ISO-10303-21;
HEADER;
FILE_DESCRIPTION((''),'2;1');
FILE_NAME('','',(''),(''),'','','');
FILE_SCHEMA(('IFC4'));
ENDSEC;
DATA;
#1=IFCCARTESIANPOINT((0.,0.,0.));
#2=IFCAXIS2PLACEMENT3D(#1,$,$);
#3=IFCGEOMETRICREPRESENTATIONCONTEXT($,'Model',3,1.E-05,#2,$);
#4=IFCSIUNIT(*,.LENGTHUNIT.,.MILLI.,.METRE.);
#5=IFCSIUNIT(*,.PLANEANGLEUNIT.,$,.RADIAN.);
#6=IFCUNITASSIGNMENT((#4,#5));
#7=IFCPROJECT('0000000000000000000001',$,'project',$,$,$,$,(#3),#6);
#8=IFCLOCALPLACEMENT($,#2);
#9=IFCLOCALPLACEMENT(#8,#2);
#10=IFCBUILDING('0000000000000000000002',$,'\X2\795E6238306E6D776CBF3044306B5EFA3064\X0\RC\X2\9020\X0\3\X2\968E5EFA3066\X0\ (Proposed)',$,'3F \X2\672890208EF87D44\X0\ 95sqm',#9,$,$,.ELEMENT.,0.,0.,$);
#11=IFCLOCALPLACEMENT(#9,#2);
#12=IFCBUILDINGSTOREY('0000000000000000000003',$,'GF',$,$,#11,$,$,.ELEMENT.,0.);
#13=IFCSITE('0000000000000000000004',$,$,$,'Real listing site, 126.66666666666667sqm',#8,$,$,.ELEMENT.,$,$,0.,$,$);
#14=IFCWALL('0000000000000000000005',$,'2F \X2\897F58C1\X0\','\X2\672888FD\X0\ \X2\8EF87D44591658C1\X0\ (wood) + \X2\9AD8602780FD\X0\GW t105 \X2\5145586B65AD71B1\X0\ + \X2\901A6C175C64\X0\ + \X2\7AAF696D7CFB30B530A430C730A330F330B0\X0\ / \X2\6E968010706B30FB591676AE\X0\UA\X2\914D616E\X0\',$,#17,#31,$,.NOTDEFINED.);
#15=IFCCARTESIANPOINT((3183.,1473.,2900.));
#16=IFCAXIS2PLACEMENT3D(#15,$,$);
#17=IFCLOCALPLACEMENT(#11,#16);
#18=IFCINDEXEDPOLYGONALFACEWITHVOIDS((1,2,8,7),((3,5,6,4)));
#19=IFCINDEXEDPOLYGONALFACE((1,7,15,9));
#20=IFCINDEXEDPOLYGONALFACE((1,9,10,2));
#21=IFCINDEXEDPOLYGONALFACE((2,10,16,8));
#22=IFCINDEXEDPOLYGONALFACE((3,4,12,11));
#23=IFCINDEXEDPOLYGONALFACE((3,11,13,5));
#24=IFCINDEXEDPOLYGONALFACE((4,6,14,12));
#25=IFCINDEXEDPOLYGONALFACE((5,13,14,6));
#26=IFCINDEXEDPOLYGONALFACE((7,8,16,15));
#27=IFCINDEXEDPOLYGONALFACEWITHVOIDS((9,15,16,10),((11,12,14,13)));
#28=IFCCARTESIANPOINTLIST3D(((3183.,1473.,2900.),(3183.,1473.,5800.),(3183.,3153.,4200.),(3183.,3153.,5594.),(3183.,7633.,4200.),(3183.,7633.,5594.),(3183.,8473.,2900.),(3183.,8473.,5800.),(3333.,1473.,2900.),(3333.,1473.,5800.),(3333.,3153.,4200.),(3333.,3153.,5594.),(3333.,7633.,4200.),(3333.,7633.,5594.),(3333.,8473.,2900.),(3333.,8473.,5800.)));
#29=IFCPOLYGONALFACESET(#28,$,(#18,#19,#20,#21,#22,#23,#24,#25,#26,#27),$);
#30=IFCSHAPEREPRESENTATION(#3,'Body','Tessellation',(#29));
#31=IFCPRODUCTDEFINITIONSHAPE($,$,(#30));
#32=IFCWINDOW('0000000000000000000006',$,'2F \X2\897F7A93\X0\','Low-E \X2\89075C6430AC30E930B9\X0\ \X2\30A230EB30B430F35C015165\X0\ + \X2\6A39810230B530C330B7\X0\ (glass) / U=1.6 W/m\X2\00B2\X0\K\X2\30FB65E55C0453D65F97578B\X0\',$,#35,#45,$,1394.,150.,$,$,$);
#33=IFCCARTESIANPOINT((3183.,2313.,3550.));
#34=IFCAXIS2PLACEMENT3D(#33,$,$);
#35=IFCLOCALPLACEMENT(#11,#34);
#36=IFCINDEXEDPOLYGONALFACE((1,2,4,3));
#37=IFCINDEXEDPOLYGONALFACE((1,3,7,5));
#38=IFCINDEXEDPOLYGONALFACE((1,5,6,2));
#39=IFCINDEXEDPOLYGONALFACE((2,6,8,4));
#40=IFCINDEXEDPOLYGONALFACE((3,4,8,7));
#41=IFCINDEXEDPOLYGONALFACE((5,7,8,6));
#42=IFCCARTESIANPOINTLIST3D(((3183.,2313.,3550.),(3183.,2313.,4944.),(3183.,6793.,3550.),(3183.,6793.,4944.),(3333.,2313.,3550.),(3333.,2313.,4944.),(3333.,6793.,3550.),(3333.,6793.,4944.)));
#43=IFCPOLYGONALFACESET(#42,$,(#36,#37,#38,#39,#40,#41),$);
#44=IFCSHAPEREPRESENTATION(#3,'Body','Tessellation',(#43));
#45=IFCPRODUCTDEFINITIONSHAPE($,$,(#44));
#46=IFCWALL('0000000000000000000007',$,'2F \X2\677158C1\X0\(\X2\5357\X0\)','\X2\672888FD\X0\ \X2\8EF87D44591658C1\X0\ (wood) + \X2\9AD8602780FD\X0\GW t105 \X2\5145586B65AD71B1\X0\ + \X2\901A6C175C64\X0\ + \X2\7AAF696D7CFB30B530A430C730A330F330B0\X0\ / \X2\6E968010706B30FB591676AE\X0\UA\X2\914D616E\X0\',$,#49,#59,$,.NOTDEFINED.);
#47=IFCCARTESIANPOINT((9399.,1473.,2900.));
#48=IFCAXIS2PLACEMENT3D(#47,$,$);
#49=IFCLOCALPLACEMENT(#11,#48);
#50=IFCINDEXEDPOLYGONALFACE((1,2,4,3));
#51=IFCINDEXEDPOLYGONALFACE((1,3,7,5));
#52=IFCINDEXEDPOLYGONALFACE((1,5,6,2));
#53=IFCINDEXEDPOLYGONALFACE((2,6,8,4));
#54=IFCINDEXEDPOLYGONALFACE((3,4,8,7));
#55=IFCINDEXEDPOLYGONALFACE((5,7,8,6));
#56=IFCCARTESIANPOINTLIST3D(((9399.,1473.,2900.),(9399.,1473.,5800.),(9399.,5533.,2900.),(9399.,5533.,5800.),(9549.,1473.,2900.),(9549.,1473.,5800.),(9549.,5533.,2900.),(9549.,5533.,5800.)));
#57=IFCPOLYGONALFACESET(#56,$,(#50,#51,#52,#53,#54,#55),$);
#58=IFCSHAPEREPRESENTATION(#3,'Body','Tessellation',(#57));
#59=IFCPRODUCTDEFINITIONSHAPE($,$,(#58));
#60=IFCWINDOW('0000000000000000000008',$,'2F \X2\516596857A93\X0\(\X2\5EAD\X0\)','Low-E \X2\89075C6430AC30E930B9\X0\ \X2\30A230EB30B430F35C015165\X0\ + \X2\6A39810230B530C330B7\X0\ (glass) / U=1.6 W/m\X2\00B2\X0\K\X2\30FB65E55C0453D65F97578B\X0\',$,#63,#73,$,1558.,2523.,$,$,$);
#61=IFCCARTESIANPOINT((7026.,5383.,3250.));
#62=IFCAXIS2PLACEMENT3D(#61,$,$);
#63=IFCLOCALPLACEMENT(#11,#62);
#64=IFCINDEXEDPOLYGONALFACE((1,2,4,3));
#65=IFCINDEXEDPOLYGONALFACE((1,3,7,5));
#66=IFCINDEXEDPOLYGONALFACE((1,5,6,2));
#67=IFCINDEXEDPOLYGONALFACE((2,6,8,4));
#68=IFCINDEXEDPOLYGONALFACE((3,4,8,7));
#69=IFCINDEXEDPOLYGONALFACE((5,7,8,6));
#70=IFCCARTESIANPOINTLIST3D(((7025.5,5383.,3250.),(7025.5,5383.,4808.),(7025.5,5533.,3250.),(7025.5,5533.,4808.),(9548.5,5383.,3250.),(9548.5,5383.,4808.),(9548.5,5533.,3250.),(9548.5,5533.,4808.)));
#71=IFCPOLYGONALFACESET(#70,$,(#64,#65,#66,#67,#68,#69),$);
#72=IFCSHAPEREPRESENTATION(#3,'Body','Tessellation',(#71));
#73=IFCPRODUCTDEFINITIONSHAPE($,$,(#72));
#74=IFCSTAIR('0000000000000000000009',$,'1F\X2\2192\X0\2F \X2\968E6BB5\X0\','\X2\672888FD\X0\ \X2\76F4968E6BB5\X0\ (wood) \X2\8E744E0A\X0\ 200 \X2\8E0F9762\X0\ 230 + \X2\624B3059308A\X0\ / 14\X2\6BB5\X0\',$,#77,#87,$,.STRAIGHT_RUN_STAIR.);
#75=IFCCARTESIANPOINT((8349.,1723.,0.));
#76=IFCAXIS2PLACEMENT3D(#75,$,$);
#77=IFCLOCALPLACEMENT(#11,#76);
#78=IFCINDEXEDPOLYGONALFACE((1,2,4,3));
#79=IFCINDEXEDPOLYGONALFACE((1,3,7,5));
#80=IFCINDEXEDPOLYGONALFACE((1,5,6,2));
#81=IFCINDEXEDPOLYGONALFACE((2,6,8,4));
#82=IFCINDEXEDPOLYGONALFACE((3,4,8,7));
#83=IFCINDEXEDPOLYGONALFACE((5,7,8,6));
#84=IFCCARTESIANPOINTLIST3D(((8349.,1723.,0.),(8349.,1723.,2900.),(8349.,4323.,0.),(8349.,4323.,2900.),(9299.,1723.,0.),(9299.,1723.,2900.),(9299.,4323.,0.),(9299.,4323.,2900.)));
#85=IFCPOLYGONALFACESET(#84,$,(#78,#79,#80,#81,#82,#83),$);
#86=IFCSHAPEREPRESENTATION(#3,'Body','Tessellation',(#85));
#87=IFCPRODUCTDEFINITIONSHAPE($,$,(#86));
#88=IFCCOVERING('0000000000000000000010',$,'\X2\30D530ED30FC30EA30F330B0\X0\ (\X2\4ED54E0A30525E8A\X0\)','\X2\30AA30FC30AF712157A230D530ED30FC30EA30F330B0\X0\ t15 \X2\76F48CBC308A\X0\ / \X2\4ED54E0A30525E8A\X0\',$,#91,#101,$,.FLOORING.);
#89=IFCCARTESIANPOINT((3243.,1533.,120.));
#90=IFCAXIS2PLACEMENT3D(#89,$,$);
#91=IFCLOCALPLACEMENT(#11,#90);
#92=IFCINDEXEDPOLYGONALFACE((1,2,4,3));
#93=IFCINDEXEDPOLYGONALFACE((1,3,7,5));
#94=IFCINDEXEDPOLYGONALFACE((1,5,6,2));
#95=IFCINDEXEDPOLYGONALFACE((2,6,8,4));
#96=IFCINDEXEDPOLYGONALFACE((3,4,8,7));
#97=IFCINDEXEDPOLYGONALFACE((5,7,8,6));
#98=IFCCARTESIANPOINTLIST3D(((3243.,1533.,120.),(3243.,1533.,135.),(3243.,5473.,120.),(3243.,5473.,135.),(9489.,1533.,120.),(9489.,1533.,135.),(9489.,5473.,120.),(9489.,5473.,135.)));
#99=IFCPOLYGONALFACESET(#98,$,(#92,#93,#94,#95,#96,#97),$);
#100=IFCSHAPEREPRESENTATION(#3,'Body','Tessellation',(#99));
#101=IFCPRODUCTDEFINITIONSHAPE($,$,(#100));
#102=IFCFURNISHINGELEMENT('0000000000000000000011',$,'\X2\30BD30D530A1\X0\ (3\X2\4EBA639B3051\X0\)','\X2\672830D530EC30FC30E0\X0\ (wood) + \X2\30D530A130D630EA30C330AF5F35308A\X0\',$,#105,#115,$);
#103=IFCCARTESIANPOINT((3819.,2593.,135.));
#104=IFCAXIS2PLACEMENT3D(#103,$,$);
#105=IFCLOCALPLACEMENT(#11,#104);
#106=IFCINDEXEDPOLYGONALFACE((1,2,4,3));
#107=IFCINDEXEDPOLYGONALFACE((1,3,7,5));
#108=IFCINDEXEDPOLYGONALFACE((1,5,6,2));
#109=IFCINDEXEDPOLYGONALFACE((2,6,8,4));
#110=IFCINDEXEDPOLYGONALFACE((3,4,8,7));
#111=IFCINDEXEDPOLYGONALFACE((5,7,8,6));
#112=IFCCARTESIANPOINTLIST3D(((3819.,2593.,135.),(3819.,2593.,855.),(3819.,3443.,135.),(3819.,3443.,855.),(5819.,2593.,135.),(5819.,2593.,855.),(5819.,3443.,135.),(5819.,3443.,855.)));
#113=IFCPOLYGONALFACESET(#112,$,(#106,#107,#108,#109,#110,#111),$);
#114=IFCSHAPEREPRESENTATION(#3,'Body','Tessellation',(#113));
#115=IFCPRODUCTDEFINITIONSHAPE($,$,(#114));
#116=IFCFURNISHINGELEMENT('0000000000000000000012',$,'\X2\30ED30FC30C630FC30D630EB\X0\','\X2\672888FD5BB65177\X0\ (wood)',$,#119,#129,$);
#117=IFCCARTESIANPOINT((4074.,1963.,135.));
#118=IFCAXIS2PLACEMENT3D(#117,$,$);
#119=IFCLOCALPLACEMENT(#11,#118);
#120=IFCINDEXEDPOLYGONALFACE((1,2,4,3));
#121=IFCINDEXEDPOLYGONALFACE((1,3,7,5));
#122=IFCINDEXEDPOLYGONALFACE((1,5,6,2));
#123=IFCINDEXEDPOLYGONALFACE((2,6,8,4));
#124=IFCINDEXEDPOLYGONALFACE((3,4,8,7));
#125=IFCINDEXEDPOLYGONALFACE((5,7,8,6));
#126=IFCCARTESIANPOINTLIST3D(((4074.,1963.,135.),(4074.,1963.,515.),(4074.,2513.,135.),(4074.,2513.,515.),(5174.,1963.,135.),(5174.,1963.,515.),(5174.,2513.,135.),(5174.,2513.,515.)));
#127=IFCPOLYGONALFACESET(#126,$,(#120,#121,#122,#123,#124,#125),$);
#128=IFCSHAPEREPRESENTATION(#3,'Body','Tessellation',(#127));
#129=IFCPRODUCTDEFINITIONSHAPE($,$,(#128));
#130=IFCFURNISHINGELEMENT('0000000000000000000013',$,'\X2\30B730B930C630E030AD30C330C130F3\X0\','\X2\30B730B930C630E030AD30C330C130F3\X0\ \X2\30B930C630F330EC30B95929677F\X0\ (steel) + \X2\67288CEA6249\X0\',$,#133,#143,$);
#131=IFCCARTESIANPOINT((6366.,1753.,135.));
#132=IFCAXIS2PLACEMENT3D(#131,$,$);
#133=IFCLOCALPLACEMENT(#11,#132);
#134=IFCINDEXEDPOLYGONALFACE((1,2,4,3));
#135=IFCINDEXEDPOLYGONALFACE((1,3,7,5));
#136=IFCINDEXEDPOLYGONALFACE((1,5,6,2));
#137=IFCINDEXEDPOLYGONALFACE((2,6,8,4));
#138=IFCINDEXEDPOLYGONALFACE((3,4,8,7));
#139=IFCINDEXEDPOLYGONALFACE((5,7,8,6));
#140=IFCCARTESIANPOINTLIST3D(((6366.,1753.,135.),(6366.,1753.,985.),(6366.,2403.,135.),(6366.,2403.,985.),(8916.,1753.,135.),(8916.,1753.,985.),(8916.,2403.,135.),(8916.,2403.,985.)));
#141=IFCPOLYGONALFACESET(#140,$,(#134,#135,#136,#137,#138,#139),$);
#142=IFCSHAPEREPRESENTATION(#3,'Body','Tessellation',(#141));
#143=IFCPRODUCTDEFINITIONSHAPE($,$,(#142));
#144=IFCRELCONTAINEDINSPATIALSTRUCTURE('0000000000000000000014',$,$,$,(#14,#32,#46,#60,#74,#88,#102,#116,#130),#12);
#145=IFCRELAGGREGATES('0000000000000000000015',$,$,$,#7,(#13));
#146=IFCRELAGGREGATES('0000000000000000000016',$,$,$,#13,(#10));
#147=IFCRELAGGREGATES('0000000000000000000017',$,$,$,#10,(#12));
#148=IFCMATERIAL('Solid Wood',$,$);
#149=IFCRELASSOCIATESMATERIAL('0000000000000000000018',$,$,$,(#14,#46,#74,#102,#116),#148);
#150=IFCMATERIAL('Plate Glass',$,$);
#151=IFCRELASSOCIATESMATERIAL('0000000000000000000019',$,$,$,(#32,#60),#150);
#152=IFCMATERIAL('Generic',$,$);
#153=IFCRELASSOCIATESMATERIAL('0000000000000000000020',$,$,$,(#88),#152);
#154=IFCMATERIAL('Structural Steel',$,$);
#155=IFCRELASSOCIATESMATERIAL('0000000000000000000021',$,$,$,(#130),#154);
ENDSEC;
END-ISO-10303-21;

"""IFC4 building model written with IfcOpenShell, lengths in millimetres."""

from ifc_helpers import new_model, si_unit, frame, frame_2d, origin, place, context, project, spatial, rectangle, extrude, material, element, fill, save


model = new_model("IFC4")

# Units and contexts
model_context = context("Model", 3, precision=1e-05, world=origin())
ifc_project = project(units=[si_unit("LENGTHUNIT", "METRE", prefix="MILLI"), si_unit("PLANEANGLEUNIT", "RADIAN")], contexts=[model_context])

# Site, building, storey
site_placement = place(None, origin())
site = spatial("IfcSite", under=ifc_project, at=site_placement, ObjectType="Real listing site, 126.66666666666667sqm", CompositionType="ELEMENT", RefElevation=0.0)
building_placement = place(site_placement, origin())
building = spatial("IfcBuilding", under=site, at=building_placement, Name="神戸の海沿いに建つRC造3階建て (Proposed)", ObjectType="3F 木造軸組 95sqm", CompositionType="ELEMENT", ElevationOfRefHeight=0.0, ElevationOfTerrain=0.0)
storey_placement = place(building_placement, origin())
storey = spatial("IfcBuildingStorey", under=building, at=storey_placement, Name="GF", CompositionType="ELEMENT", Elevation=0.0)

# Shared definitions
ifc_material_1 = material(Name="Solid Wood")

# Shared definitions
ifc_material_2 = material(Name="Plate Glass")

# Walls, openings, windows
wall_1_placement = place(storey_placement, frame((3183.0, 1473.0, 2900.0)))
wall_1 = element("IfcWall", 1, at=wall_1_placement, inside=storey, material=ifc_material_1, Name="2F 西壁", Description="木製 軸組外壁 (wood) + 高性能GW t105 充填断熱 + 通気層 + 窯業系サイディング / 準耐火・外皮UA配慮", PredefinedType="NOTDEFINED", context=model_context, shape_type="SweptSolid", body=[
    extrude(rectangle(XDim=150.0, YDim=7000.0, at=frame_2d((75.0, 3500.0))), frame((3183.0, 1473.0, 2900.0)), (0.0, 0.0, 1.0), 2900.0),
])
opening_1_placement = place(storey_placement, frame((3183.0, 2313.0, 3550.0)))
opening_1 = element("IfcOpeningElement", 2, at=opening_1_placement, cuts=wall_1, PredefinedType="NOTDEFINED", context=model_context, shape_type="SweptSolid", body=[
    extrude(rectangle(XDim=150.0, YDim=4480.0, at=frame_2d((75.0, 2240.0))), frame((3183.0, 2313.0, 3550.0)), (0.0, 0.0, 1.0), 1394.0),
])
window_1_placement = place(storey_placement, frame((3183.0, 2313.0, 3550.0)))
window_1 = element("IfcWindow", 3, at=window_1_placement, inside=storey, material=ifc_material_2, Name="2F 西窓", Description="Low-E 複層ガラス アルゴン封入 + 樹脂サッシ (glass) / U=1.6 W/m²K・日射取得型", OverallHeight=1394.0, OverallWidth=150.0, context=model_context, shape_type="SweptSolid", body=[
    extrude(rectangle(XDim=150.0, YDim=4480.0, at=frame_2d((75.0, 2240.0))), frame((3183.0, 2313.0, 3550.0)), (0.0, 0.0, 1.0), 1394.0),
])
fill(opening_1, window_1)
wall_2_placement = place(storey_placement, frame((9399.0, 1473.0, 2900.0)))
wall_2 = element("IfcWall", 4, at=wall_2_placement, inside=storey, material=ifc_material_1, Name="2F 東壁(南)", Description="木製 軸組外壁 (wood) + 高性能GW t105 充填断熱 + 通気層 + 窯業系サイディング / 準耐火・外皮UA配慮", PredefinedType="NOTDEFINED", context=model_context, shape_type="SweptSolid", body=[
    extrude(rectangle(XDim=150.0, YDim=4060.0, at=frame_2d((75.0, 2030.0))), frame((9399.0, 1473.0, 2900.0)), (0.0, 0.0, 1.0), 2900.0),
])
opening_2_placement = place(storey_placement, frame((7026.0, 5383.0, 3250.0)))
opening_2 = element("IfcOpeningElement", 5, at=opening_2_placement, cuts=wall_2, PredefinedType="NOTDEFINED", context=model_context, shape_type="SweptSolid", body=[
    extrude(rectangle(XDim=2523.0, YDim=150.0, at=frame_2d((1261.0, 75.0))), frame((7026.0, 5383.0, 3250.0)), (0.0, 0.0, 1.0), 1558.0),
])
window_2_placement = place(storey_placement, frame((7026.0, 5383.0, 3250.0)))
window_2 = element("IfcWindow", 6, at=window_2_placement, inside=storey, material=ifc_material_2, Name="2F 入隅窓(庭)", Description="Low-E 複層ガラス アルゴン封入 + 樹脂サッシ (glass) / U=1.6 W/m²K・日射取得型", OverallHeight=1558.0, OverallWidth=2523.0, context=model_context, shape_type="SweptSolid", body=[
    extrude(rectangle(XDim=2523.0, YDim=150.0, at=frame_2d((1261.0, 75.0))), frame((7026.0, 5383.0, 3250.0)), (0.0, 0.0, 1.0), 1558.0),
])
fill(opening_2, window_2)

# Stair
stair_placement = place(storey_placement, frame((8349.0, 1723.0, 0.0)))
element("IfcStair", 7, at=stair_placement, inside=storey, material=ifc_material_1, Name="1F→2F 階段", Description="木製 直階段 (wood) 蹴上 200 踏面 230 + 手すり / 14段", PredefinedType="STRAIGHT_RUN_STAIR", context=model_context, shape_type="SweptSolid", body=[
    extrude(rectangle(XDim=950.0, YDim=2600.0, at=frame_2d((475.0, 1300.0))), frame((8349.0, 1723.0, 0.0)), (0.0, 0.0, 1.0), 2900.0),
])

# Covering
ifc_material_3 = material(Name="Generic")
covering_placement = place(storey_placement, frame((3243.0, 1533.0, 120.0)))
element("IfcCovering", 8, at=covering_placement, inside=storey, material=ifc_material_3, Name="フローリング (仕上げ床)", Description="オーク無垢フローリング t15 直貼り / 仕上げ床", PredefinedType="FLOORING", context=model_context, shape_type="SweptSolid", body=[
    extrude(rectangle(XDim=6246.0, YDim=3940.0, at=frame_2d((3123.0, 1970.0))), frame((3243.0, 1533.0, 120.0)), (0.0, 0.0, 1.0), 15.0),
])

# Furnishing elements
furnishing_1_placement = place(storey_placement, frame((3819.0, 2593.0, 135.0)))
element("IfcFurnishingElement", 9, at=furnishing_1_placement, inside=storey, material=ifc_material_1, Name="ソファ (3人掛け)", Description="木フレーム (wood) + ファブリック張り", context=model_context, shape_type="SweptSolid", body=[
    extrude(rectangle(XDim=2000.0, YDim=850.0, at=frame_2d((1000.0, 425.0))), frame((3819.0, 2593.0, 135.0)), (0.0, 0.0, 1.0), 720.0),
])
furnishing_2_placement = place(storey_placement, frame((4074.0, 1963.0, 135.0)))
element("IfcFurnishingElement", 10, at=furnishing_2_placement, inside=storey, material=ifc_material_1, Name="ローテーブル", Description="木製家具 (wood)", context=model_context, shape_type="SweptSolid", body=[
    extrude(rectangle(XDim=1100.0, YDim=550.0, at=frame_2d((550.0, 275.0))), frame((4074.0, 1963.0, 135.0)), (0.0, 0.0, 1.0), 380.0),
])
ifc_material_4 = material(Name="Structural Steel")
furnishing_3_placement = place(storey_placement, frame((6366.0, 1753.0, 135.0)))
element("IfcFurnishingElement", 11, at=furnishing_3_placement, inside=storey, material=ifc_material_4, Name="システムキッチン", Description="システムキッチン ステンレス天板 (steel) + 木質扉", context=model_context, shape_type="SweptSolid", body=[
    extrude(rectangle(XDim=2550.0, YDim=650.0, at=frame_2d((1275.0, 325.0))), frame((6366.0, 1753.0, 135.0)), (0.0, 0.0, 1.0), 850.0),
])

save(model, "model.ifc")
